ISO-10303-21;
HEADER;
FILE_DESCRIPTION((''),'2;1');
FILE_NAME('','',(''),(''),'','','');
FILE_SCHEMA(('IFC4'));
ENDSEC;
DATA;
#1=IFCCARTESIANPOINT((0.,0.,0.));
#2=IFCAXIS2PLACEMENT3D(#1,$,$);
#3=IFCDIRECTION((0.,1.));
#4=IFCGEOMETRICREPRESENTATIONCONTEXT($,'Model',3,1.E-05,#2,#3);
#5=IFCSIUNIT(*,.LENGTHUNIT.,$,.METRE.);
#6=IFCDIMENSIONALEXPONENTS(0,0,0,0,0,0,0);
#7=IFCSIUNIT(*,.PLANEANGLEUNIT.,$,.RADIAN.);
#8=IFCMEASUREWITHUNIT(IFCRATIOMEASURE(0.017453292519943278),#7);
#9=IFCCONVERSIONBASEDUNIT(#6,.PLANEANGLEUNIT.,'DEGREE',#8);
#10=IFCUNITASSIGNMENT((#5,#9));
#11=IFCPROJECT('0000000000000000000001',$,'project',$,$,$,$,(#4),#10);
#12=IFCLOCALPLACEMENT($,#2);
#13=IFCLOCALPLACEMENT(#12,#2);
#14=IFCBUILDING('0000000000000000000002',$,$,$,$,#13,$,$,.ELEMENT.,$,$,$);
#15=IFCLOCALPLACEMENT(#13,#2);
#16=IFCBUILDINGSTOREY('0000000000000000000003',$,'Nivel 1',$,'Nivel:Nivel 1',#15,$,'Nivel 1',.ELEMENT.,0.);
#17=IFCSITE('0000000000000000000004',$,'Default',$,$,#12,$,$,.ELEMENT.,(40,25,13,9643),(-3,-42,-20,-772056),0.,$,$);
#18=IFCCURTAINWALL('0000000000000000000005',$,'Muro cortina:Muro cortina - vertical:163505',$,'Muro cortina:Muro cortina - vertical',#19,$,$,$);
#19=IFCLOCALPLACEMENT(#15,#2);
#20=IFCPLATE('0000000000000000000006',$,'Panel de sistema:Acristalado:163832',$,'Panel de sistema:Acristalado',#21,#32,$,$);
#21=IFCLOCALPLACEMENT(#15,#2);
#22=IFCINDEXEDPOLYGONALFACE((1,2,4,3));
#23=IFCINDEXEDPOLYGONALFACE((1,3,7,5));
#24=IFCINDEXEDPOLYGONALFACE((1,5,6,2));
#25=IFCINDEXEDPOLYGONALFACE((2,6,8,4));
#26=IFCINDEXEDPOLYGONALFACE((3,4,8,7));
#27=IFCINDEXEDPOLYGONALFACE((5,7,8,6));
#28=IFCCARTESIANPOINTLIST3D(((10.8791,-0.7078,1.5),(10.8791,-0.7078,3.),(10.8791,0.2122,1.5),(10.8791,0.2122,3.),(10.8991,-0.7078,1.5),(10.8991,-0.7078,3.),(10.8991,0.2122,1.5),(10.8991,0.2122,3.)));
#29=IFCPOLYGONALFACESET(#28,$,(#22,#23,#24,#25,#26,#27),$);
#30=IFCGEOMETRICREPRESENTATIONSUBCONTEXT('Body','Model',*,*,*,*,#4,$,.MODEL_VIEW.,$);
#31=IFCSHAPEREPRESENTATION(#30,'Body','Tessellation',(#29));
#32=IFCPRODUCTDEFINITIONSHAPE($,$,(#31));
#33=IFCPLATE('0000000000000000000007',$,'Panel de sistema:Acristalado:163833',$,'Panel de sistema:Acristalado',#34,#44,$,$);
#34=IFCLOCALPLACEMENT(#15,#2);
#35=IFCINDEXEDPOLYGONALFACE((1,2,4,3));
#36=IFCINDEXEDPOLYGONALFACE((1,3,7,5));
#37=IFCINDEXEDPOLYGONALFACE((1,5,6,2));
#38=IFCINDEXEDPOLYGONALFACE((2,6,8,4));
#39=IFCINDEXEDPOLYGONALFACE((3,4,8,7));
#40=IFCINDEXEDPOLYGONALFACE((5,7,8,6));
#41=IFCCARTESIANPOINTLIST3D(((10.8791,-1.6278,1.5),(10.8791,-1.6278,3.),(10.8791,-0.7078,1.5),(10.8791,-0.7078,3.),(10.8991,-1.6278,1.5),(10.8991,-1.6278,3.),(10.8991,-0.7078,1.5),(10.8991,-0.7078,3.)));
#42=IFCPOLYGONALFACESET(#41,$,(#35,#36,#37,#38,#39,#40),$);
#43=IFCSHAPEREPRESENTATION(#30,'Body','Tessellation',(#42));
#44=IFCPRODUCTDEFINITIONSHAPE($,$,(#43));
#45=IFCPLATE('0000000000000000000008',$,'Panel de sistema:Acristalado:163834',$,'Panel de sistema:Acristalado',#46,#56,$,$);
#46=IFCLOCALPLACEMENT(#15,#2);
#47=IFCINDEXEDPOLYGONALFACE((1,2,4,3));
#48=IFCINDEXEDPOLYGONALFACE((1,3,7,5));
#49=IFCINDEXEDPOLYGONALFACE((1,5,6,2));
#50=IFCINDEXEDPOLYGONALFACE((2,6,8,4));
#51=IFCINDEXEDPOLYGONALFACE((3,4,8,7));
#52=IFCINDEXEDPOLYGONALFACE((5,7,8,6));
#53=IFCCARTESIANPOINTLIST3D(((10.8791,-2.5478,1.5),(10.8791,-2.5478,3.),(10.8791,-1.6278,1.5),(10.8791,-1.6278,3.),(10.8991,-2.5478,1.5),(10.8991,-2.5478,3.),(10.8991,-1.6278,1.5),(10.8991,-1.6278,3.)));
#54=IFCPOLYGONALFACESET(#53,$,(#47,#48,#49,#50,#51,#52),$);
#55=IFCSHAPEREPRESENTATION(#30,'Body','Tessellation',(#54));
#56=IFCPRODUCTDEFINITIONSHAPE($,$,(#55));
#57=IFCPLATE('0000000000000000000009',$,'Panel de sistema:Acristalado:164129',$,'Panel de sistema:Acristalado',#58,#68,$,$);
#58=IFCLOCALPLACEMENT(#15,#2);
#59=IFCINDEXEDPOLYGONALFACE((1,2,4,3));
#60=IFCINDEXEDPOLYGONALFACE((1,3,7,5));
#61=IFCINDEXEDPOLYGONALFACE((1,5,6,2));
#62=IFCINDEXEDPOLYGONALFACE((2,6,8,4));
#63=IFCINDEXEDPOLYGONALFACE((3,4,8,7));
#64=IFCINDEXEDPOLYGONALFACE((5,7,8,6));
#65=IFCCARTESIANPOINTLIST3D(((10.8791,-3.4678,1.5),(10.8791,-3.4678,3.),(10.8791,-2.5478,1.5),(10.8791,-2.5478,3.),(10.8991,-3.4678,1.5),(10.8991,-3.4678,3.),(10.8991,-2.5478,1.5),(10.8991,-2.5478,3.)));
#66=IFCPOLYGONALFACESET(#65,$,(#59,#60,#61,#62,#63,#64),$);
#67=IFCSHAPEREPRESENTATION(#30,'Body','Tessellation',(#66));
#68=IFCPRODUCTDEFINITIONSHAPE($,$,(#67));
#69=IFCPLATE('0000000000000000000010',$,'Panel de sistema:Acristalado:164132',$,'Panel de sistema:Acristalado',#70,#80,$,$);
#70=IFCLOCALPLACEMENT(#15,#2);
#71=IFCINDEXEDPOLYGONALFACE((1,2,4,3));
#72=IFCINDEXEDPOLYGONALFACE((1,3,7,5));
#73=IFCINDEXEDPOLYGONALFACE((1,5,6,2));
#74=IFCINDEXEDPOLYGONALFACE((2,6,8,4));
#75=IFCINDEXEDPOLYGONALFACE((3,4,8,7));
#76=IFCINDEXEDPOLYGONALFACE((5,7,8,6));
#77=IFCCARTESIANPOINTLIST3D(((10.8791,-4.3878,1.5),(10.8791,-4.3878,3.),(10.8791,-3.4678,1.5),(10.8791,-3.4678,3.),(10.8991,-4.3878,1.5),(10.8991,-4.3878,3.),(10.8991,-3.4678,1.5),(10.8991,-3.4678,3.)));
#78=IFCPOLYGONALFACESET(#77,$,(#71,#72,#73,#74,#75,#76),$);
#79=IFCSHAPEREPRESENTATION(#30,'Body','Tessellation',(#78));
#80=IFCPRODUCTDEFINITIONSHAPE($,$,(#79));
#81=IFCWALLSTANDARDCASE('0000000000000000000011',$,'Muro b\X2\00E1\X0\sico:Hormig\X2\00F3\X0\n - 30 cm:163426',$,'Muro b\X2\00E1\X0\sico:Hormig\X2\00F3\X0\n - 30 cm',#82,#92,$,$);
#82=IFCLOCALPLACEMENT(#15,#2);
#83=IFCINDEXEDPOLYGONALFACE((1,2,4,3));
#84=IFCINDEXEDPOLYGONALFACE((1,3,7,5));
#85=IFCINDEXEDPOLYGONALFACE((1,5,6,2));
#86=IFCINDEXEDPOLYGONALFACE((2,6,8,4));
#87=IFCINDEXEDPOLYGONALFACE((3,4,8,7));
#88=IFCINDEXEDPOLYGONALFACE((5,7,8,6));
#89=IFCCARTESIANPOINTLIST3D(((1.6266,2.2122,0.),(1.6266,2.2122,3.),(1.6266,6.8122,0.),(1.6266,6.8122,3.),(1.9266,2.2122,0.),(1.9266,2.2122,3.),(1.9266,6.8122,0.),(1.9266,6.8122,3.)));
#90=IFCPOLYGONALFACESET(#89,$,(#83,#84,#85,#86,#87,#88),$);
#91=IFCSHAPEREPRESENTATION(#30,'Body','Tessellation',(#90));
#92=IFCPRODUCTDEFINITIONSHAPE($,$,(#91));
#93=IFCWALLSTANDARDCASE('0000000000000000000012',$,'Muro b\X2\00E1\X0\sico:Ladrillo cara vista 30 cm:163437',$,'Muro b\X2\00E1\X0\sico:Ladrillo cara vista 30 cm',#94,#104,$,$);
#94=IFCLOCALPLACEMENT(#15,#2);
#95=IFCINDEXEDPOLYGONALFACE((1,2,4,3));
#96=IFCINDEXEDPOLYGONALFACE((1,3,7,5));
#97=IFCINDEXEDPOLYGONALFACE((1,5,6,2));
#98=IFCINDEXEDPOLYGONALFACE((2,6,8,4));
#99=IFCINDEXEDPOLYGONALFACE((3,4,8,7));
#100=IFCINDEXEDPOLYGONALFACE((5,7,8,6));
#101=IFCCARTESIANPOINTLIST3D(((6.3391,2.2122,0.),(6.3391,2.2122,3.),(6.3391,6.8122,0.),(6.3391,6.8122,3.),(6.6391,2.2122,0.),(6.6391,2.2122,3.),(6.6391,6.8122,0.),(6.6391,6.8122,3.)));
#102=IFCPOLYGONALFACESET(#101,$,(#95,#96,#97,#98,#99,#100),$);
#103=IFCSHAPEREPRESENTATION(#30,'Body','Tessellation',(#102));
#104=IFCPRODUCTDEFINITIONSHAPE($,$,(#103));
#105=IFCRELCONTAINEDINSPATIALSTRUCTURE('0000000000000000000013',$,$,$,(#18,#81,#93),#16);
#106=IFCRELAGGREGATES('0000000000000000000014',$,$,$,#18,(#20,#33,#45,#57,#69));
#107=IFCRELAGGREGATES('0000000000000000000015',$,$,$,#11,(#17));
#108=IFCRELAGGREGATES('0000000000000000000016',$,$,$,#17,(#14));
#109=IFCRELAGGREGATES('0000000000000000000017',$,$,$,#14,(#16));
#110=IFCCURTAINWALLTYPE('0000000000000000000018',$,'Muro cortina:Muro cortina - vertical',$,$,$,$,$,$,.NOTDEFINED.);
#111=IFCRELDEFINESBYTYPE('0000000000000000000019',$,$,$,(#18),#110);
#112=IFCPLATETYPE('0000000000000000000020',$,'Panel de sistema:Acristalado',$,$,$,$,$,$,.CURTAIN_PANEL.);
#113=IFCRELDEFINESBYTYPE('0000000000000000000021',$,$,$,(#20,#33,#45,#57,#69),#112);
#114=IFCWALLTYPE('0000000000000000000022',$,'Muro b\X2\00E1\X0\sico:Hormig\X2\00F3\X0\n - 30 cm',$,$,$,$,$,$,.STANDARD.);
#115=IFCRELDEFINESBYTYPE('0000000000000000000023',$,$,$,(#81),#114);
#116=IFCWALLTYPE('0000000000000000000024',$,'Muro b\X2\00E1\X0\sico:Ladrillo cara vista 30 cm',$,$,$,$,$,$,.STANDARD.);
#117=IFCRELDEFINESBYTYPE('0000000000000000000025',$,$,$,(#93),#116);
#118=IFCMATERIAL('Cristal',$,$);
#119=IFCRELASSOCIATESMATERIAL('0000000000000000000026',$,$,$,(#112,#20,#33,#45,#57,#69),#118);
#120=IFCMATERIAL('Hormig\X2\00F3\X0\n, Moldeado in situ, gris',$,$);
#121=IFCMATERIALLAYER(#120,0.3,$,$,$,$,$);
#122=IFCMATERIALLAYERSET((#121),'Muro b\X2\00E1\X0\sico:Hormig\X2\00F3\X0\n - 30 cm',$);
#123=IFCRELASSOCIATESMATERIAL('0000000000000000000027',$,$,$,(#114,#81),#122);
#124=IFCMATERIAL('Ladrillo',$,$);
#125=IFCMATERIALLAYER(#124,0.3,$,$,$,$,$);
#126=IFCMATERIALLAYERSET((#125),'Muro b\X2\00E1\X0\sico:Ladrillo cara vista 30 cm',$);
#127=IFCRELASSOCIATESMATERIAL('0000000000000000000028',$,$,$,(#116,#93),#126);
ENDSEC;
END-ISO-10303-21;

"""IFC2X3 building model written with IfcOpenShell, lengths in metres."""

from ifc_helpers import new_model, entity, si_unit, converted_unit, direction, frame, frame_2d, origin, origin_2d_with_axis, place, context, subcontext, project, spatial, rectangle, extrude, source, transform, mapped, material, layer, layer_set, layer_usage, type_object, type_shapes, element, aggregate, save


model = new_model("IFC2X3")

# Units and contexts
model_context = context("Model", 3, precision=1e-05, world=origin(), true_north=direction((0.0, 1.0)))
body_context = subcontext(model_context, "Body", "Model", "MODEL_VIEW")
ifc_project = project(units=[si_unit("LENGTHUNIT", "METRE"), converted_unit("PLANEANGLEUNIT", "DEGREE", entity("IfcRatioMeasure", 0.017453292519943278), si_unit("PLANEANGLEUNIT", "RADIAN"), dimensions=[0, 0, 0, 0, 0, 0, 0])], contexts=[model_context])

# Site, building, storey
site_placement = place(None, origin())
site = spatial("IfcSite", under=ifc_project, at=site_placement, Name="Default", CompositionType="ELEMENT", RefLatitude=(40, 25, 13, 9643), RefLongitude=(-3, -42, -20, -772056), RefElevation=0.0)
building_placement = place(site_placement, origin())
building = spatial("IfcBuilding", under=site, at=building_placement, CompositionType="ELEMENT")
storey_placement = place(building_placement, origin())
storey = spatial("IfcBuildingStorey", under=building, at=storey_placement, Name="Nivel 1", ObjectType="Nivel:Nivel 1", LongName="Nivel 1", CompositionType="ELEMENT", Elevation=0.0)

# Shared definitions
ifc_material_1 = material(Name="Cristal")

# Curtain wall, plates
curtain_wall_type_1 = type_object("IfcCurtainWallType", Name="Muro cortina:Muro cortina - vertical", PredefinedType="NOTDEFINED")
curtain_wall_1_placement = place(storey_placement, origin())
curtain_wall_1 = element("IfcCurtainWall", 1, at=curtain_wall_1_placement, inside=storey, type_object=curtain_wall_type_1, Name="Muro cortina:Muro cortina - vertical:163505", ObjectType="Muro cortina:Muro cortina - vertical")
plate_type_1 = type_object("IfcPlateType", Name="Panel de sistema:Acristalado", PredefinedType="CURTAIN_PANEL", material=ifc_material_1)
shared_shape_1 = source(origin(), body_context, "Body", "SweptSolid", [
    extrude(rectangle(XDim=0.02, YDim=0.92, at=origin_2d_with_axis()), frame((0.0, 0.0, 0.0), z_axis=(0.0, 0.0, 1.0), x_axis=(0.0, 1.0, 0.0)), (0.0, 0.0, 1.0), 1.5),
])
type_shapes(plate_type_1, [shared_shape_1])
plate_1_placement = place(curtain_wall_1_placement, frame((10.8891, -0.2478, 1.5), z_axis=(0.0, 0.0, 1.0), x_axis=(0.0, -1.0, 0.0)))
plate_1 = element("IfcPlate", 2, at=plate_1_placement, type_object=plate_type_1, material=ifc_material_1, Name="Panel de sistema:Acristalado:163832", ObjectType="Panel de sistema:Acristalado", context=body_context, shape_type="MappedRepresentation", body=[
    mapped(shared_shape_1, transform((0.0, 0.0, 0.0), scale=1.0)),
])
plate_2_placement = place(curtain_wall_1_placement, frame((10.8891, -1.1678, 1.5), z_axis=(0.0, 0.0, 1.0), x_axis=(0.0, -1.0, 0.0)))
plate_2 = element("IfcPlate", 3, at=plate_2_placement, type_object=plate_type_1, material=ifc_material_1, Name="Panel de sistema:Acristalado:163833", ObjectType="Panel de sistema:Acristalado", context=body_context, shape_type="MappedRepresentation", body=[
    mapped(shared_shape_1, transform((0.0, 0.0, 0.0), scale=1.0)),
])
plate_3_placement = place(curtain_wall_1_placement, frame((10.8891, -2.0878, 1.5), z_axis=(0.0, 0.0, 1.0), x_axis=(0.0, -1.0, 0.0)))
plate_3 = element("IfcPlate", 4, at=plate_3_placement, type_object=plate_type_1, material=ifc_material_1, Name="Panel de sistema:Acristalado:163834", ObjectType="Panel de sistema:Acristalado", context=body_context, shape_type="MappedRepresentation", body=[
    mapped(shared_shape_1, transform((0.0, 0.0, 0.0), scale=1.0)),
])
plate_4_placement = place(curtain_wall_1_placement, frame((10.8891, -3.0078, 1.5), z_axis=(0.0, 0.0, 1.0), x_axis=(0.0, -1.0, 0.0)))
plate_4 = element("IfcPlate", 5, at=plate_4_placement, type_object=plate_type_1, material=ifc_material_1, Name="Panel de sistema:Acristalado:164129", ObjectType="Panel de sistema:Acristalado", context=body_context, shape_type="MappedRepresentation", body=[
    mapped(shared_shape_1, transform((0.0, 0.0, 0.0), scale=1.0)),
])
plate_5_placement = place(curtain_wall_1_placement, frame((10.8891, -3.9278, 1.5), z_axis=(0.0, 0.0, 1.0), x_axis=(0.0, -1.0, 0.0)))
plate_5 = element("IfcPlate", 6, at=plate_5_placement, type_object=plate_type_1, material=ifc_material_1, Name="Panel de sistema:Acristalado:164132", ObjectType="Panel de sistema:Acristalado", context=body_context, shape_type="MappedRepresentation", body=[
    mapped(shared_shape_1, transform((0.0, 0.0, 0.0), scale=1.0)),
])
aggregate(curtain_wall_1, [plate_1, plate_2, plate_3, plate_4, plate_5])

# Walls
ifc_material_2 = material(Name="Hormigón, Moldeado in situ, gris")
ifc_layer_1 = layer(ifc_material_2, 0.3)
ifc_layer_set_1 = layer_set([ifc_layer_1], Name="Muro básico:Hormigón - 30 cm")
ifc_layer_usage_1 = layer_usage(ifc_layer_set_1, "AXIS2", "NEGATIVE", 0.15)
wall_type_1 = type_object("IfcWallType", Name="Muro básico:Hormigón - 30 cm", PredefinedType="STANDARD", material=ifc_layer_set_1)
wall_1_placement = place(storey_placement, frame((1.7766, 6.8122, 0.0), z_axis=(0.0, 0.0, 1.0), x_axis=(0.0, -1.0, 0.0)))
element("IfcWallStandardCase", 7, at=wall_1_placement, inside=storey, type_object=wall_type_1, material=ifc_layer_usage_1, Name="Muro básico:Hormigón - 30 cm:163426", ObjectType="Muro básico:Hormigón - 30 cm", context=body_context, shape_type="SweptSolid", body=[
    extrude(rectangle(XDim=4.6, YDim=0.3, at=frame_2d((2.3, 0.0), x_axis=(-1.0, 0.0))), origin(), (0.0, 0.0, 1.0), 3.0),
])
ifc_material_3 = material(Name="Ladrillo")
ifc_layer_2 = layer(ifc_material_3, 0.3)
ifc_layer_set_2 = layer_set([ifc_layer_2], Name="Muro básico:Ladrillo cara vista 30 cm")
ifc_layer_usage_2 = layer_usage(ifc_layer_set_2, "AXIS2", "NEGATIVE", 0.15)
wall_type_2 = type_object("IfcWallType", Name="Muro básico:Ladrillo cara vista 30 cm", PredefinedType="STANDARD", material=ifc_layer_set_2)
wall_2_placement = place(storey_placement, frame((6.4891, 6.8122, 0.0), z_axis=(0.0, 0.0, 1.0), x_axis=(0.0, -1.0, 0.0)))
element("IfcWallStandardCase", 8, at=wall_2_placement, inside=storey, type_object=wall_type_2, material=ifc_layer_usage_2, Name="Muro básico:Ladrillo cara vista 30 cm:163437", ObjectType="Muro básico:Ladrillo cara vista 30 cm", context=body_context, shape_type="SweptSolid", body=[
    extrude(rectangle(XDim=4.6, YDim=0.3, at=frame_2d((2.3, 0.0), x_axis=(-1.0, 0.0))), origin(), (0.0, 0.0, 1.0), 3.0),
])

save(model, "model.ifc")
